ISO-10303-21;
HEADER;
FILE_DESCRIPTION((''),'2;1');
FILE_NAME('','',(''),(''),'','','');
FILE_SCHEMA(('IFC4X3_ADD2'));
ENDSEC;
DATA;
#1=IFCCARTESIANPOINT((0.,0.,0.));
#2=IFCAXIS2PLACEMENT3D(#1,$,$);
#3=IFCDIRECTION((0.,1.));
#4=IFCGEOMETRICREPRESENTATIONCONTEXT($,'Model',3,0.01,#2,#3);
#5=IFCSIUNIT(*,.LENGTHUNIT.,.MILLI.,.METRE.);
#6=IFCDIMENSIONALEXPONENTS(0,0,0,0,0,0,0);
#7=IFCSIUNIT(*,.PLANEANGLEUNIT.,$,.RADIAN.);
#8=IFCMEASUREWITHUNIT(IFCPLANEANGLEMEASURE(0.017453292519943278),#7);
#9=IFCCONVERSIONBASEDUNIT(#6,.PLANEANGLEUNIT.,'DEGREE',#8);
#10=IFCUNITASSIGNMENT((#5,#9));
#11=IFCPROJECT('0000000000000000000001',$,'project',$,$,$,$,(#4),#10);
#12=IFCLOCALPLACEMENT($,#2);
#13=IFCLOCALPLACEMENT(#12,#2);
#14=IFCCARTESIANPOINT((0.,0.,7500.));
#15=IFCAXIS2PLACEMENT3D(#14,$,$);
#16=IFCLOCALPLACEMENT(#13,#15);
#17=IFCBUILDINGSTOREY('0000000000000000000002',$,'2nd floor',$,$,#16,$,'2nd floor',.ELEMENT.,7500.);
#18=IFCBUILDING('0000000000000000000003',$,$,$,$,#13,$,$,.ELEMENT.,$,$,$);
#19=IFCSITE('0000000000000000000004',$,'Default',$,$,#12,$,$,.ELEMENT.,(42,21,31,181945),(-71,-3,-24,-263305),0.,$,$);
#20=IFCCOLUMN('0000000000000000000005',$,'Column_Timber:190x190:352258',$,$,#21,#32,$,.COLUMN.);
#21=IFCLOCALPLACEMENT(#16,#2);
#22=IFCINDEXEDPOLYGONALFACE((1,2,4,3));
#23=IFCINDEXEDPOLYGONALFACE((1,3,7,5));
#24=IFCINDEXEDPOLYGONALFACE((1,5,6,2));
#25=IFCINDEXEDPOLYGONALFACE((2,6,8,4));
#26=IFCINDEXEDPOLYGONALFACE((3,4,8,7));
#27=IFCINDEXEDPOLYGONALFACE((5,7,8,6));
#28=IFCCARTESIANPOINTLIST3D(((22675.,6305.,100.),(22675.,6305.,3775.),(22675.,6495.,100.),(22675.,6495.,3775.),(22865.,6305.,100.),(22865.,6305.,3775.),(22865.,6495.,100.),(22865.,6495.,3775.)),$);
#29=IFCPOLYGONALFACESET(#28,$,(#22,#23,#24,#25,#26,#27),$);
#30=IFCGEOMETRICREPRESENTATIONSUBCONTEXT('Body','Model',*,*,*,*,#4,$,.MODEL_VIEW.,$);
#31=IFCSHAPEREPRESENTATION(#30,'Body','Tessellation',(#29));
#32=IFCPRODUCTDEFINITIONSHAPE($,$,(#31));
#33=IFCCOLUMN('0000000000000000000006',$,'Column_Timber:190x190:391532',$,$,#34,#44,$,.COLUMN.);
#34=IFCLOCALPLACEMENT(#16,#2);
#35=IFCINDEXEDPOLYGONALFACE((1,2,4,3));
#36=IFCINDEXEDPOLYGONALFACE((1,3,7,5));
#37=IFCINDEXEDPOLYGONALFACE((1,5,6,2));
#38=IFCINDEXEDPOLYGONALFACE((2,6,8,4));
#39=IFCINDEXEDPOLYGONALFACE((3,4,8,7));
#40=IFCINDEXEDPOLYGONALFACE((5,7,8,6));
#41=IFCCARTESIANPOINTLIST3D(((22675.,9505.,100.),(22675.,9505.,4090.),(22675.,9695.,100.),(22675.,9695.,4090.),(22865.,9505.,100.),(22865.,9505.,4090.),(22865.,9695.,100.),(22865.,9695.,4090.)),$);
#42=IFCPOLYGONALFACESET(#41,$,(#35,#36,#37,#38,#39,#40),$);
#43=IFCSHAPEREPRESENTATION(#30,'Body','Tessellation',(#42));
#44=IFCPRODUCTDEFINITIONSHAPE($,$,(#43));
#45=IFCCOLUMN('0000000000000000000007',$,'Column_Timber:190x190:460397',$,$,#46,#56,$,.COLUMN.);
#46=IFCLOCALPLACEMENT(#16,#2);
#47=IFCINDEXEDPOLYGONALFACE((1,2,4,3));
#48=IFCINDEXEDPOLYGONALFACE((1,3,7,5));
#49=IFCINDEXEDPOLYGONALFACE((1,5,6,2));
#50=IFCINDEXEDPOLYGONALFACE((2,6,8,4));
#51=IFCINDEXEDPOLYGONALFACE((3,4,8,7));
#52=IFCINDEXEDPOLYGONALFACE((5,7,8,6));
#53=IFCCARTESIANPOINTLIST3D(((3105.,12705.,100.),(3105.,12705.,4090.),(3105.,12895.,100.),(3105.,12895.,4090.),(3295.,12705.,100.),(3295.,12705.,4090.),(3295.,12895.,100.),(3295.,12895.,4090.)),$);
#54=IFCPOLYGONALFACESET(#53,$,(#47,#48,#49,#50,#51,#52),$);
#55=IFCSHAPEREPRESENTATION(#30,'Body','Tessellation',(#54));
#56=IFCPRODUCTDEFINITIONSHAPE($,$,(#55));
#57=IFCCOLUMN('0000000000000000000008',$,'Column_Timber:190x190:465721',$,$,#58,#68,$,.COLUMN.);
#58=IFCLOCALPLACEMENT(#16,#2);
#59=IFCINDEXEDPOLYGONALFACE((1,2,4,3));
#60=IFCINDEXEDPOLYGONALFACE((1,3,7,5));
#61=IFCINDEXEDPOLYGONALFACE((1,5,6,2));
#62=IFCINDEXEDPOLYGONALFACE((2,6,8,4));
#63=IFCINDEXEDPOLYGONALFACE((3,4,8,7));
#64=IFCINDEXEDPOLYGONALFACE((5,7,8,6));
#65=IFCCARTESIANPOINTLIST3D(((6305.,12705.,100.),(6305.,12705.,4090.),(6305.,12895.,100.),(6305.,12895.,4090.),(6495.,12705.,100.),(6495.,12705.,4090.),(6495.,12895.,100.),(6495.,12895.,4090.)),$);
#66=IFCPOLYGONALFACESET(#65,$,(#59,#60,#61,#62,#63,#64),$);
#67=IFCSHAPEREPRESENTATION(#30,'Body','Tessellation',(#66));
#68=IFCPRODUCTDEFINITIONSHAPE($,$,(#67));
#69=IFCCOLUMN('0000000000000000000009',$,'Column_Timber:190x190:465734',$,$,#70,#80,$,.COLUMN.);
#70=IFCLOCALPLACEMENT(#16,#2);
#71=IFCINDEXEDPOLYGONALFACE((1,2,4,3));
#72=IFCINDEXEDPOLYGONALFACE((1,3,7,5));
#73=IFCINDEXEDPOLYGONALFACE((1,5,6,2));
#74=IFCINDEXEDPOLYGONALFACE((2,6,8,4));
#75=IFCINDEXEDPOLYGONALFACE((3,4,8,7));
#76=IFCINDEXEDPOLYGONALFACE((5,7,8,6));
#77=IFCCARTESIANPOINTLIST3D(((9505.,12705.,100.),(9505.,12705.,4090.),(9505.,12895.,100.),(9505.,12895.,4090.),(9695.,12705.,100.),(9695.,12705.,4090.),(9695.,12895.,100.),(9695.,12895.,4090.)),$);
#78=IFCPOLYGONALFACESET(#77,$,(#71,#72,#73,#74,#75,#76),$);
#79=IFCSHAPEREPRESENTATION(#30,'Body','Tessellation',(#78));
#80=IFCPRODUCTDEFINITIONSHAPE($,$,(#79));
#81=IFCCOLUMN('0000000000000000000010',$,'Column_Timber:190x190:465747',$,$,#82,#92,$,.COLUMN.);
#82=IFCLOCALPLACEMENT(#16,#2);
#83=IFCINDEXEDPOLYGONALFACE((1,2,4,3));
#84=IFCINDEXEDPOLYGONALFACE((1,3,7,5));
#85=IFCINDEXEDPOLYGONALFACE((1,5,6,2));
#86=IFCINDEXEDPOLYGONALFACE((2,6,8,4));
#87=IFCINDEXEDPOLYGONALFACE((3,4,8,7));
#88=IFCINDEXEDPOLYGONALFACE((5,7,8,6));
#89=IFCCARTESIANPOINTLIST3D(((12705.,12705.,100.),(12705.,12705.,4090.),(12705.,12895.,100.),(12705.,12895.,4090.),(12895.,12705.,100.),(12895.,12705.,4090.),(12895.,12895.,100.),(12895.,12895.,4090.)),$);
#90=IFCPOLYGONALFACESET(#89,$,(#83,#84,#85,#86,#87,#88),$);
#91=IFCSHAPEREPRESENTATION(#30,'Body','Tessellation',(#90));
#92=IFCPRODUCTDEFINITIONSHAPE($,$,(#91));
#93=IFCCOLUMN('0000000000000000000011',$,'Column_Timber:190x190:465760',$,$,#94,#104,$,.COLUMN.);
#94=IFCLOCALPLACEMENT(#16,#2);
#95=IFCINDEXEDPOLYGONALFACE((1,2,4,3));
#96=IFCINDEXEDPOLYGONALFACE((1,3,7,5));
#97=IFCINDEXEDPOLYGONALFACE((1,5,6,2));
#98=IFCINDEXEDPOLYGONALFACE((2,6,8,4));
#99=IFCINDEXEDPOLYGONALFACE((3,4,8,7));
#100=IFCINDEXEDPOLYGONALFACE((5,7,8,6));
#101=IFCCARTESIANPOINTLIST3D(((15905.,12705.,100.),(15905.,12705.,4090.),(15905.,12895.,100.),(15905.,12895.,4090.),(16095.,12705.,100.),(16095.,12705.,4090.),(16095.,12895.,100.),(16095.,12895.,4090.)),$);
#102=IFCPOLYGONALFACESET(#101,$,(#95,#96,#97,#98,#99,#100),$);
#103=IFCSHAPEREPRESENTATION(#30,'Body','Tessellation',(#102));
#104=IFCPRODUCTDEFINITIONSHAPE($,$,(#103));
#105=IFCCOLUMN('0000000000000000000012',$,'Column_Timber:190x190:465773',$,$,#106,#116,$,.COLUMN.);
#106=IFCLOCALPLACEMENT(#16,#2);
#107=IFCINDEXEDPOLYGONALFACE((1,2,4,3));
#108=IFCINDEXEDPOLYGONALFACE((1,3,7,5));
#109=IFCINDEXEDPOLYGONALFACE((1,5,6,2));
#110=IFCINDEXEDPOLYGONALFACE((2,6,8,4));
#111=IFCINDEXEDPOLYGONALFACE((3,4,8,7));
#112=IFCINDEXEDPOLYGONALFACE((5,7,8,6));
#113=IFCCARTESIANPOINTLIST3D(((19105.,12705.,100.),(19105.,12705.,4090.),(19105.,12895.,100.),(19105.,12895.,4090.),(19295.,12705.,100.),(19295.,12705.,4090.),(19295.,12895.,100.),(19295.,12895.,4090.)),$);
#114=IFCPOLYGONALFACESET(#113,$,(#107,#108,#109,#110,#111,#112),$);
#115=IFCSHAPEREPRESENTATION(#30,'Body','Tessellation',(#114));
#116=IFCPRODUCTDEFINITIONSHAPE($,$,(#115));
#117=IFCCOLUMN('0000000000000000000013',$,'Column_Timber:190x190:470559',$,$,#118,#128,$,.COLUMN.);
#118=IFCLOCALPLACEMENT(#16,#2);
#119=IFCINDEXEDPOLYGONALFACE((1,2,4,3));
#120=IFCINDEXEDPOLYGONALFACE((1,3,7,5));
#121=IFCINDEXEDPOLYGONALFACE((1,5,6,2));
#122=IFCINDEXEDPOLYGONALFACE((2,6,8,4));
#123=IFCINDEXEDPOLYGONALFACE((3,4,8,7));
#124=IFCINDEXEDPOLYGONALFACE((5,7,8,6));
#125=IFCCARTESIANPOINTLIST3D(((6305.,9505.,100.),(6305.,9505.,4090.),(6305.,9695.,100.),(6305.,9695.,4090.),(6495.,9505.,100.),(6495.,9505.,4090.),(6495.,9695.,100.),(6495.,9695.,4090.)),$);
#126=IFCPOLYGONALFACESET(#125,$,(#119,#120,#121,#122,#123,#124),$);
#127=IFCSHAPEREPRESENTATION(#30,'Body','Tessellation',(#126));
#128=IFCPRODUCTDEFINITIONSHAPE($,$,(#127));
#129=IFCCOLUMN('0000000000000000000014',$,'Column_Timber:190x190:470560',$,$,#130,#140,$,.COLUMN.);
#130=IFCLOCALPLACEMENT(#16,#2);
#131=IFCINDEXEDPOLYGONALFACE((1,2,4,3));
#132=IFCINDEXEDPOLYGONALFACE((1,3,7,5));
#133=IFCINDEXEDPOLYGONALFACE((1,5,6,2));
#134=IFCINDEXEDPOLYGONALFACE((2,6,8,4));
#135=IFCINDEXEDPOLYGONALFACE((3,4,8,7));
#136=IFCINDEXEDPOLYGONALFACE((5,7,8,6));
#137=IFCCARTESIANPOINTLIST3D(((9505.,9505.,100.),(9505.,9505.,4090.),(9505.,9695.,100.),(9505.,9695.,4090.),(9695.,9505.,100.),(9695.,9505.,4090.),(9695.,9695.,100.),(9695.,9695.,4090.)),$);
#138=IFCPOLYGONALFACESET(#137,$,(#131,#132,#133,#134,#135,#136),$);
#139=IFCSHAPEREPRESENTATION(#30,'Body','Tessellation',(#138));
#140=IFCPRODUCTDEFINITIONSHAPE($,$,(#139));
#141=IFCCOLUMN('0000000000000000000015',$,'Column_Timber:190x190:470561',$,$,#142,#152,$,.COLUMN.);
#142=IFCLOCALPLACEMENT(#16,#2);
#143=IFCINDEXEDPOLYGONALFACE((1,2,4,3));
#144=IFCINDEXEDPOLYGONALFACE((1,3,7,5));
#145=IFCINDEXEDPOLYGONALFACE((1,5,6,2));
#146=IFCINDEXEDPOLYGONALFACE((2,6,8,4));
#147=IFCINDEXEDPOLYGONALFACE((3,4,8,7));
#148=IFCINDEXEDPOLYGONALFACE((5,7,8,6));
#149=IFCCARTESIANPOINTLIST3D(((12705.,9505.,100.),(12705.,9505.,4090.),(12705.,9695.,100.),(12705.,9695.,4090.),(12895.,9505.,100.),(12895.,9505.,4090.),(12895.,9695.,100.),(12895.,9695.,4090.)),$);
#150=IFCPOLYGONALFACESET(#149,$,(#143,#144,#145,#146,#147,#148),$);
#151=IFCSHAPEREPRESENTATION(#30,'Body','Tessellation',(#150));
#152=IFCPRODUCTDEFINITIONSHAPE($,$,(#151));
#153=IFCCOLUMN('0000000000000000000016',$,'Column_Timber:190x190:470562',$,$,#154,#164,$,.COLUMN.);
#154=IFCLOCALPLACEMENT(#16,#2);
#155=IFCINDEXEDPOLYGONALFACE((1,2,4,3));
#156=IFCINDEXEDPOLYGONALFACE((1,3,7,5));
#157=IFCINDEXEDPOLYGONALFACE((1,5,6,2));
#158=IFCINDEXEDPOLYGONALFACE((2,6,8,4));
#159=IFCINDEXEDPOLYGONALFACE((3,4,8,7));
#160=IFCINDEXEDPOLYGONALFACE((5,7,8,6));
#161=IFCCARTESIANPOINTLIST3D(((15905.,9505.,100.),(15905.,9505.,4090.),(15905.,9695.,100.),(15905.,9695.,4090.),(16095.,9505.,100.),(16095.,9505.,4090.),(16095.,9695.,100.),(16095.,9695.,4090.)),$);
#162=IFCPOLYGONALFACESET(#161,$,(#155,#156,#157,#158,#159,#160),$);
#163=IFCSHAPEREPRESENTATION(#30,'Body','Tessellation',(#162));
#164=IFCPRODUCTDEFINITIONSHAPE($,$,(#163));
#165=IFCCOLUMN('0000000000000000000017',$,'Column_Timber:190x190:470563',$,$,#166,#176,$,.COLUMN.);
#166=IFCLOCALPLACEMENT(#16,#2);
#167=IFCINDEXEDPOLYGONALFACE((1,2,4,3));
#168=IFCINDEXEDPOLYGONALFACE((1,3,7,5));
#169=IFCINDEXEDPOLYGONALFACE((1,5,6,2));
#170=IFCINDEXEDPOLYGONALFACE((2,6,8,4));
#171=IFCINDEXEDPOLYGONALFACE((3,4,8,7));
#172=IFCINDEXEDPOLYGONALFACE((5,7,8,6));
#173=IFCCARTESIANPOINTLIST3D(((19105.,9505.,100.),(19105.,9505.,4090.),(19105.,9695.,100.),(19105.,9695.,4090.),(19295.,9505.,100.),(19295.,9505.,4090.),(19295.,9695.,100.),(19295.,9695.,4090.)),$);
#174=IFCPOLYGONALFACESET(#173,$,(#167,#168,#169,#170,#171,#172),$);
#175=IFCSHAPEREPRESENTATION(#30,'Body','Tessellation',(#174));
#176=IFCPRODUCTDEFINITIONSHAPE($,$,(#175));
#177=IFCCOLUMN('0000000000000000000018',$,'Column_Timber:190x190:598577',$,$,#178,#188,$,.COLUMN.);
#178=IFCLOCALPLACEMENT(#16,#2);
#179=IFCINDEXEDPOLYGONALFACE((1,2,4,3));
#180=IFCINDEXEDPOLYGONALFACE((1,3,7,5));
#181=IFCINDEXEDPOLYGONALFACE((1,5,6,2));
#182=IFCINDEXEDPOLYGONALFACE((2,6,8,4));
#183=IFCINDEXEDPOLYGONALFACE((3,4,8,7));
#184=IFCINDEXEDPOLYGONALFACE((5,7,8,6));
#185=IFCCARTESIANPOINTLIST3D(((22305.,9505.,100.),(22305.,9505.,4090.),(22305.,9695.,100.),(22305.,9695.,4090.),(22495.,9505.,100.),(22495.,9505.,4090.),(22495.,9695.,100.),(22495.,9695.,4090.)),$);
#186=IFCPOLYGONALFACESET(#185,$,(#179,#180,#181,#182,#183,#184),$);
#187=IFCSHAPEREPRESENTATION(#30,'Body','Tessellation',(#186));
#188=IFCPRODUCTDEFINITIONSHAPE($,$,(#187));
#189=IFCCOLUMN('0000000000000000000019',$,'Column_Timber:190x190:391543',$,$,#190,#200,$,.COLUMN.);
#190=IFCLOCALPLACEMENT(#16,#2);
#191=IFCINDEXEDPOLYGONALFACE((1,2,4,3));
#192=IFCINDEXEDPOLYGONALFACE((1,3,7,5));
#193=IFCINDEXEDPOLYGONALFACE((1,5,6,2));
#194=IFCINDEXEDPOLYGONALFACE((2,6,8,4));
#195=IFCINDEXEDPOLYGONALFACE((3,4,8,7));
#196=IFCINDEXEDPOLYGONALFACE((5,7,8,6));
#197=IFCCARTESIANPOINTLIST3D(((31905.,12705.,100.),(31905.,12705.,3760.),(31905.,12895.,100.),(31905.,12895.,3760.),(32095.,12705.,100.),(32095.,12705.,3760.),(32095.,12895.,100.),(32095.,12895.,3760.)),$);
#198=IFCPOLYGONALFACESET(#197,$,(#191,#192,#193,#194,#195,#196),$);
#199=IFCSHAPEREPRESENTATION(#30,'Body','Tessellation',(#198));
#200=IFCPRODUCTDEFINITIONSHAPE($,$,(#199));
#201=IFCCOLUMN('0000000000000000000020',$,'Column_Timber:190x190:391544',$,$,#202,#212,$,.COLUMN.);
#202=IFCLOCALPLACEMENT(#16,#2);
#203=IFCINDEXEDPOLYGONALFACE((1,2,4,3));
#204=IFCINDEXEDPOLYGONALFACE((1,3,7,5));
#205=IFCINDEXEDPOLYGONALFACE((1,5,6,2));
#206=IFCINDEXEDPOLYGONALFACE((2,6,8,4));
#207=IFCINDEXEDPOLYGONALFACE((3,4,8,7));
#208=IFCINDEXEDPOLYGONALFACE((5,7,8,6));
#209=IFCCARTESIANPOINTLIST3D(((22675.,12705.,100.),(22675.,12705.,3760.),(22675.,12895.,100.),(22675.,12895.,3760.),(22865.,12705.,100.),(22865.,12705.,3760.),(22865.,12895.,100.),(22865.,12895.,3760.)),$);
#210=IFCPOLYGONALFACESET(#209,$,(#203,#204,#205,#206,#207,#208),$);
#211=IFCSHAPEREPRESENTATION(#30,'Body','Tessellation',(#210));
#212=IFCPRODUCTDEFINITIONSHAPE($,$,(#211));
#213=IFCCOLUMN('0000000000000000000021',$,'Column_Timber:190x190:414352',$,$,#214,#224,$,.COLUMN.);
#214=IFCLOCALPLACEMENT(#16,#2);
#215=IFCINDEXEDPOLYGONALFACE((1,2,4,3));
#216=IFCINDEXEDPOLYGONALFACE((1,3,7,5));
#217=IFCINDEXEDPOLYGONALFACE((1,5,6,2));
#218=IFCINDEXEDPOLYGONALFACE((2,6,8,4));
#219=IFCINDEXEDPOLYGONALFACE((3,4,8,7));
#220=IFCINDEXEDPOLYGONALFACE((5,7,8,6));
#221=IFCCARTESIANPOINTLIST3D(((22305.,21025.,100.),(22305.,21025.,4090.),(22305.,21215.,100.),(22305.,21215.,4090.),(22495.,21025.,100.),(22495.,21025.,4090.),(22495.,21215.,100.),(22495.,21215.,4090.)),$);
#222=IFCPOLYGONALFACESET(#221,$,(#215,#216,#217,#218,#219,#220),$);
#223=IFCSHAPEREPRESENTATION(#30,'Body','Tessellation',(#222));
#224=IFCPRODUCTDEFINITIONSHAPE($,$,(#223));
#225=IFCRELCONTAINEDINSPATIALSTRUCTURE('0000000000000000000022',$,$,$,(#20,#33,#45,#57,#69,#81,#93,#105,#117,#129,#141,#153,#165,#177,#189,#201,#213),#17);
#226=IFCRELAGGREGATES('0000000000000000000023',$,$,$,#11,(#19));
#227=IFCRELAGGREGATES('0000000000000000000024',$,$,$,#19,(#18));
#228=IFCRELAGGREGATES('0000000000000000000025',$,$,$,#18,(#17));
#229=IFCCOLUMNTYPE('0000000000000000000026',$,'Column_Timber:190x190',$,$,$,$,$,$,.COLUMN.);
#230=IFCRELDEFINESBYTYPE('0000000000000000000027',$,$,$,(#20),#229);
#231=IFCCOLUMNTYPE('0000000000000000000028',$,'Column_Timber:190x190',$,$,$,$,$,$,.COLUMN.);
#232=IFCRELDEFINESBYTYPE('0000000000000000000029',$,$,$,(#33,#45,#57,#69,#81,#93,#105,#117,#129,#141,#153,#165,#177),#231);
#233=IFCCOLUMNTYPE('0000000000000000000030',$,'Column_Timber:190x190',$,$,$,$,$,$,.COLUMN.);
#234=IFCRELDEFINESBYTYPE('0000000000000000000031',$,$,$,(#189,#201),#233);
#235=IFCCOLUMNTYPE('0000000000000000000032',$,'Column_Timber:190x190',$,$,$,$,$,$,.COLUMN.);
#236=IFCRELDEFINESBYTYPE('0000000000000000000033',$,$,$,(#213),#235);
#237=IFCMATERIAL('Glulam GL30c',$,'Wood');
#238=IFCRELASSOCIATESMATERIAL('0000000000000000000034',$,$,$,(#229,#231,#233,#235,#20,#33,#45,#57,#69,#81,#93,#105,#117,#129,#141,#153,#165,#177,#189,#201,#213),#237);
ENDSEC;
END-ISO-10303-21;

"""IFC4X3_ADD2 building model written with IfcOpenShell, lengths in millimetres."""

from ifc_helpers import new_model, entity, si_unit, converted_unit, direction, frame, origin, origin_2d_with_axis, place, context, subcontext, project, spatial, rectangle, extrude, source, transform, mapped, material, material_profile, profile_set, profile_usage, type_object, type_shapes, element, save


model = new_model("IFC4X3_ADD2")

# Units and contexts
model_context = context("Model", 3, precision=0.01, world=origin(), true_north=direction((0.0, 1.0)))
body_context = subcontext(model_context, "Body", "Model", "MODEL_VIEW")
ifc_project = project(units=[si_unit("LENGTHUNIT", "METRE", prefix="MILLI"), converted_unit("PLANEANGLEUNIT", "DEGREE", entity("IfcPlaneAngleMeasure", 0.017453292519943278), si_unit("PLANEANGLEUNIT", "RADIAN"), dimensions=[0, 0, 0, 0, 0, 0, 0])], contexts=[model_context])

# Site, building, storey
site_placement = place(None, origin())
site = spatial("IfcSite", under=ifc_project, at=site_placement, Name="Default", CompositionType="ELEMENT", RefLatitude=(42, 21, 31, 181945), RefLongitude=(-71, -3, -24, -263305), RefElevation=0.0)
building_placement = place(site_placement, origin())
building = spatial("IfcBuilding", under=site, at=building_placement, CompositionType="ELEMENT")
storey_placement = place(building_placement, frame((0.0, 0.0, 7500.0)))
storey = spatial("IfcBuildingStorey", under=building, at=storey_placement, Name="2nd floor", LongName="2nd floor", CompositionType="ELEMENT", Elevation=7500.0)

# Columns
ifc_material_1 = material(Name="Glulam GL30c", Category="Wood")
ifc_material_profile_1 = material_profile(ifc_material_1, rectangle(XDim=190.0, YDim=190.0, at=origin_2d_with_axis()), Name="190x190")
ifc_profile_set_1 = profile_set([ifc_material_profile_1], Name="190x190")
ifc_profile_usage_1 = profile_usage(ifc_profile_set_1)
column_type_1 = type_object("IfcColumnType", Name="Column_Timber:190x190", PredefinedType="COLUMN", material=ifc_profile_set_1)
shared_shape_1 = source(origin(), body_context, "Body", "SweptSolid", [
    extrude(rectangle(XDim=190.0, YDim=190.0, at=origin_2d_with_axis()), frame((0.0, 0.0, 7600.0), z_axis=(0.0, 0.0, 1.0), x_axis=(-1.0, 0.0, 0.0)), (0.0, 0.0, 1.0), 3675.0),
])
type_shapes(column_type_1, [shared_shape_1])
column_1_placement = place(storey_placement, frame((22770.0, 6400.0, -7500.0)))
element("IfcColumn", 1, at=column_1_placement, inside=storey, type_object=column_type_1, material=ifc_profile_usage_1, Name="Column_Timber:190x190:352258", PredefinedType="COLUMN", context=body_context, shape_type="MappedRepresentation", body=[
    mapped(shared_shape_1, transform((0.0, 0.0, 0.0), scale=1.0)),
])
column_type_2 = type_object("IfcColumnType", Name="Column_Timber:190x190", PredefinedType="COLUMN", material=ifc_profile_set_1)
shared_shape_2 = source(origin(), body_context, "Body", "SweptSolid", [
    extrude(rectangle(XDim=190.0, YDim=190.0, at=origin_2d_with_axis()), frame((0.0, 0.0, 7600.0), z_axis=(0.0, 0.0, 1.0), x_axis=(-1.0, 0.0, 0.0)), (0.0, 0.0, 1.0), 3990.0),
])
type_shapes(column_type_2, [shared_shape_2])
for number, where, name in (
    (2, (22770.0, 9600.0, -7500.0), "Column_Timber:190x190:391532"),
    (3, (3200.0, 12800.0, -7500.0), "Column_Timber:190x190:460397"),
    (4, (6400.0, 12800.0, -7500.0), "Column_Timber:190x190:465721"),
    (5, (9600.0, 12800.0, -7500.0), "Column_Timber:190x190:465734"),
    (6, (12800.0, 12800.0, -7500.0), "Column_Timber:190x190:465747"),
    (7, (16000.0, 12800.0, -7500.0), "Column_Timber:190x190:465760"),
    (8, (19200.0, 12800.0, -7500.0), "Column_Timber:190x190:465773"),
    (9, (6400.0, 9600.0, -7500.0), "Column_Timber:190x190:470559"),
    (10, (9600.0, 9600.0, -7500.0), "Column_Timber:190x190:470560"),
    (11, (12800.0, 9600.0, -7500.0), "Column_Timber:190x190:470561"),
    (12, (16000.0, 9600.0, -7500.0), "Column_Timber:190x190:470562"),
    (13, (19200.0, 9600.0, -7500.0), "Column_Timber:190x190:470563"),
    (14, (22400.0, 9600.0, -7500.0), "Column_Timber:190x190:598577"),
):
    element("IfcColumn", number, at=place(storey_placement, frame(where)), inside=storey, type_object=column_type_2, material=ifc_profile_usage_1, Name=name, PredefinedType="COLUMN", context=body_context, shape_type="MappedRepresentation", body=[
        mapped(shared_shape_2, transform((0.0, 0.0, 0.0), scale=1.0)),
    ])
column_type_3 = type_object("IfcColumnType", Name="Column_Timber:190x190", PredefinedType="COLUMN", material=ifc_profile_set_1)
shared_shape_3 = source(origin(), body_context, "Body", "SweptSolid", [
    extrude(rectangle(XDim=190.0, YDim=190.0, at=origin_2d_with_axis()), frame((0.0, 0.0, 7600.0), z_axis=(0.0, 0.0, 1.0), x_axis=(-1.0, 0.0, 0.0)), (0.0, 0.0, 1.0), 3660.0),
])
type_shapes(column_type_3, [shared_shape_3])
for number, where, name in (
    (15, (32000.0, 12800.0, -7500.0), "Column_Timber:190x190:391543"),
    (16, (22770.0, 12800.0, -7500.0), "Column_Timber:190x190:391544"),
):
    element("IfcColumn", number, at=place(storey_placement, frame(where)), inside=storey, type_object=column_type_3, material=ifc_profile_usage_1, Name=name, PredefinedType="COLUMN", context=body_context, shape_type="MappedRepresentation", body=[
        mapped(shared_shape_3, transform((0.0, 0.0, 0.0), scale=1.0)),
    ])
column_type_4 = type_object("IfcColumnType", Name="Column_Timber:190x190", PredefinedType="COLUMN", material=ifc_profile_set_1)
shared_shape_4 = source(origin(), body_context, "Body", "SweptSolid", [
    extrude(rectangle(XDim=190.0, YDim=190.0, at=origin_2d_with_axis()), frame((0.0, 0.0, 7600.0), z_axis=(0.0, 0.0, 1.0), x_axis=(-1.0, 0.0, 0.0)), (0.0, 0.0, 1.0), 3990.0),
])
type_shapes(column_type_4, [shared_shape_4])
for number, where, name in (
    (17, (22400.0, 21120.0, -7500.0), "Column_Timber:190x190:414352"),
):
    element("IfcColumn", number, at=place(storey_placement, frame(where)), inside=storey, type_object=column_type_4, material=ifc_profile_usage_1, Name=name, PredefinedType="COLUMN", context=body_context, shape_type="MappedRepresentation", body=[
        mapped(shared_shape_4, transform((0.0, 0.0, 0.0), scale=1.0)),
    ])

save(model, "model.ifc")
